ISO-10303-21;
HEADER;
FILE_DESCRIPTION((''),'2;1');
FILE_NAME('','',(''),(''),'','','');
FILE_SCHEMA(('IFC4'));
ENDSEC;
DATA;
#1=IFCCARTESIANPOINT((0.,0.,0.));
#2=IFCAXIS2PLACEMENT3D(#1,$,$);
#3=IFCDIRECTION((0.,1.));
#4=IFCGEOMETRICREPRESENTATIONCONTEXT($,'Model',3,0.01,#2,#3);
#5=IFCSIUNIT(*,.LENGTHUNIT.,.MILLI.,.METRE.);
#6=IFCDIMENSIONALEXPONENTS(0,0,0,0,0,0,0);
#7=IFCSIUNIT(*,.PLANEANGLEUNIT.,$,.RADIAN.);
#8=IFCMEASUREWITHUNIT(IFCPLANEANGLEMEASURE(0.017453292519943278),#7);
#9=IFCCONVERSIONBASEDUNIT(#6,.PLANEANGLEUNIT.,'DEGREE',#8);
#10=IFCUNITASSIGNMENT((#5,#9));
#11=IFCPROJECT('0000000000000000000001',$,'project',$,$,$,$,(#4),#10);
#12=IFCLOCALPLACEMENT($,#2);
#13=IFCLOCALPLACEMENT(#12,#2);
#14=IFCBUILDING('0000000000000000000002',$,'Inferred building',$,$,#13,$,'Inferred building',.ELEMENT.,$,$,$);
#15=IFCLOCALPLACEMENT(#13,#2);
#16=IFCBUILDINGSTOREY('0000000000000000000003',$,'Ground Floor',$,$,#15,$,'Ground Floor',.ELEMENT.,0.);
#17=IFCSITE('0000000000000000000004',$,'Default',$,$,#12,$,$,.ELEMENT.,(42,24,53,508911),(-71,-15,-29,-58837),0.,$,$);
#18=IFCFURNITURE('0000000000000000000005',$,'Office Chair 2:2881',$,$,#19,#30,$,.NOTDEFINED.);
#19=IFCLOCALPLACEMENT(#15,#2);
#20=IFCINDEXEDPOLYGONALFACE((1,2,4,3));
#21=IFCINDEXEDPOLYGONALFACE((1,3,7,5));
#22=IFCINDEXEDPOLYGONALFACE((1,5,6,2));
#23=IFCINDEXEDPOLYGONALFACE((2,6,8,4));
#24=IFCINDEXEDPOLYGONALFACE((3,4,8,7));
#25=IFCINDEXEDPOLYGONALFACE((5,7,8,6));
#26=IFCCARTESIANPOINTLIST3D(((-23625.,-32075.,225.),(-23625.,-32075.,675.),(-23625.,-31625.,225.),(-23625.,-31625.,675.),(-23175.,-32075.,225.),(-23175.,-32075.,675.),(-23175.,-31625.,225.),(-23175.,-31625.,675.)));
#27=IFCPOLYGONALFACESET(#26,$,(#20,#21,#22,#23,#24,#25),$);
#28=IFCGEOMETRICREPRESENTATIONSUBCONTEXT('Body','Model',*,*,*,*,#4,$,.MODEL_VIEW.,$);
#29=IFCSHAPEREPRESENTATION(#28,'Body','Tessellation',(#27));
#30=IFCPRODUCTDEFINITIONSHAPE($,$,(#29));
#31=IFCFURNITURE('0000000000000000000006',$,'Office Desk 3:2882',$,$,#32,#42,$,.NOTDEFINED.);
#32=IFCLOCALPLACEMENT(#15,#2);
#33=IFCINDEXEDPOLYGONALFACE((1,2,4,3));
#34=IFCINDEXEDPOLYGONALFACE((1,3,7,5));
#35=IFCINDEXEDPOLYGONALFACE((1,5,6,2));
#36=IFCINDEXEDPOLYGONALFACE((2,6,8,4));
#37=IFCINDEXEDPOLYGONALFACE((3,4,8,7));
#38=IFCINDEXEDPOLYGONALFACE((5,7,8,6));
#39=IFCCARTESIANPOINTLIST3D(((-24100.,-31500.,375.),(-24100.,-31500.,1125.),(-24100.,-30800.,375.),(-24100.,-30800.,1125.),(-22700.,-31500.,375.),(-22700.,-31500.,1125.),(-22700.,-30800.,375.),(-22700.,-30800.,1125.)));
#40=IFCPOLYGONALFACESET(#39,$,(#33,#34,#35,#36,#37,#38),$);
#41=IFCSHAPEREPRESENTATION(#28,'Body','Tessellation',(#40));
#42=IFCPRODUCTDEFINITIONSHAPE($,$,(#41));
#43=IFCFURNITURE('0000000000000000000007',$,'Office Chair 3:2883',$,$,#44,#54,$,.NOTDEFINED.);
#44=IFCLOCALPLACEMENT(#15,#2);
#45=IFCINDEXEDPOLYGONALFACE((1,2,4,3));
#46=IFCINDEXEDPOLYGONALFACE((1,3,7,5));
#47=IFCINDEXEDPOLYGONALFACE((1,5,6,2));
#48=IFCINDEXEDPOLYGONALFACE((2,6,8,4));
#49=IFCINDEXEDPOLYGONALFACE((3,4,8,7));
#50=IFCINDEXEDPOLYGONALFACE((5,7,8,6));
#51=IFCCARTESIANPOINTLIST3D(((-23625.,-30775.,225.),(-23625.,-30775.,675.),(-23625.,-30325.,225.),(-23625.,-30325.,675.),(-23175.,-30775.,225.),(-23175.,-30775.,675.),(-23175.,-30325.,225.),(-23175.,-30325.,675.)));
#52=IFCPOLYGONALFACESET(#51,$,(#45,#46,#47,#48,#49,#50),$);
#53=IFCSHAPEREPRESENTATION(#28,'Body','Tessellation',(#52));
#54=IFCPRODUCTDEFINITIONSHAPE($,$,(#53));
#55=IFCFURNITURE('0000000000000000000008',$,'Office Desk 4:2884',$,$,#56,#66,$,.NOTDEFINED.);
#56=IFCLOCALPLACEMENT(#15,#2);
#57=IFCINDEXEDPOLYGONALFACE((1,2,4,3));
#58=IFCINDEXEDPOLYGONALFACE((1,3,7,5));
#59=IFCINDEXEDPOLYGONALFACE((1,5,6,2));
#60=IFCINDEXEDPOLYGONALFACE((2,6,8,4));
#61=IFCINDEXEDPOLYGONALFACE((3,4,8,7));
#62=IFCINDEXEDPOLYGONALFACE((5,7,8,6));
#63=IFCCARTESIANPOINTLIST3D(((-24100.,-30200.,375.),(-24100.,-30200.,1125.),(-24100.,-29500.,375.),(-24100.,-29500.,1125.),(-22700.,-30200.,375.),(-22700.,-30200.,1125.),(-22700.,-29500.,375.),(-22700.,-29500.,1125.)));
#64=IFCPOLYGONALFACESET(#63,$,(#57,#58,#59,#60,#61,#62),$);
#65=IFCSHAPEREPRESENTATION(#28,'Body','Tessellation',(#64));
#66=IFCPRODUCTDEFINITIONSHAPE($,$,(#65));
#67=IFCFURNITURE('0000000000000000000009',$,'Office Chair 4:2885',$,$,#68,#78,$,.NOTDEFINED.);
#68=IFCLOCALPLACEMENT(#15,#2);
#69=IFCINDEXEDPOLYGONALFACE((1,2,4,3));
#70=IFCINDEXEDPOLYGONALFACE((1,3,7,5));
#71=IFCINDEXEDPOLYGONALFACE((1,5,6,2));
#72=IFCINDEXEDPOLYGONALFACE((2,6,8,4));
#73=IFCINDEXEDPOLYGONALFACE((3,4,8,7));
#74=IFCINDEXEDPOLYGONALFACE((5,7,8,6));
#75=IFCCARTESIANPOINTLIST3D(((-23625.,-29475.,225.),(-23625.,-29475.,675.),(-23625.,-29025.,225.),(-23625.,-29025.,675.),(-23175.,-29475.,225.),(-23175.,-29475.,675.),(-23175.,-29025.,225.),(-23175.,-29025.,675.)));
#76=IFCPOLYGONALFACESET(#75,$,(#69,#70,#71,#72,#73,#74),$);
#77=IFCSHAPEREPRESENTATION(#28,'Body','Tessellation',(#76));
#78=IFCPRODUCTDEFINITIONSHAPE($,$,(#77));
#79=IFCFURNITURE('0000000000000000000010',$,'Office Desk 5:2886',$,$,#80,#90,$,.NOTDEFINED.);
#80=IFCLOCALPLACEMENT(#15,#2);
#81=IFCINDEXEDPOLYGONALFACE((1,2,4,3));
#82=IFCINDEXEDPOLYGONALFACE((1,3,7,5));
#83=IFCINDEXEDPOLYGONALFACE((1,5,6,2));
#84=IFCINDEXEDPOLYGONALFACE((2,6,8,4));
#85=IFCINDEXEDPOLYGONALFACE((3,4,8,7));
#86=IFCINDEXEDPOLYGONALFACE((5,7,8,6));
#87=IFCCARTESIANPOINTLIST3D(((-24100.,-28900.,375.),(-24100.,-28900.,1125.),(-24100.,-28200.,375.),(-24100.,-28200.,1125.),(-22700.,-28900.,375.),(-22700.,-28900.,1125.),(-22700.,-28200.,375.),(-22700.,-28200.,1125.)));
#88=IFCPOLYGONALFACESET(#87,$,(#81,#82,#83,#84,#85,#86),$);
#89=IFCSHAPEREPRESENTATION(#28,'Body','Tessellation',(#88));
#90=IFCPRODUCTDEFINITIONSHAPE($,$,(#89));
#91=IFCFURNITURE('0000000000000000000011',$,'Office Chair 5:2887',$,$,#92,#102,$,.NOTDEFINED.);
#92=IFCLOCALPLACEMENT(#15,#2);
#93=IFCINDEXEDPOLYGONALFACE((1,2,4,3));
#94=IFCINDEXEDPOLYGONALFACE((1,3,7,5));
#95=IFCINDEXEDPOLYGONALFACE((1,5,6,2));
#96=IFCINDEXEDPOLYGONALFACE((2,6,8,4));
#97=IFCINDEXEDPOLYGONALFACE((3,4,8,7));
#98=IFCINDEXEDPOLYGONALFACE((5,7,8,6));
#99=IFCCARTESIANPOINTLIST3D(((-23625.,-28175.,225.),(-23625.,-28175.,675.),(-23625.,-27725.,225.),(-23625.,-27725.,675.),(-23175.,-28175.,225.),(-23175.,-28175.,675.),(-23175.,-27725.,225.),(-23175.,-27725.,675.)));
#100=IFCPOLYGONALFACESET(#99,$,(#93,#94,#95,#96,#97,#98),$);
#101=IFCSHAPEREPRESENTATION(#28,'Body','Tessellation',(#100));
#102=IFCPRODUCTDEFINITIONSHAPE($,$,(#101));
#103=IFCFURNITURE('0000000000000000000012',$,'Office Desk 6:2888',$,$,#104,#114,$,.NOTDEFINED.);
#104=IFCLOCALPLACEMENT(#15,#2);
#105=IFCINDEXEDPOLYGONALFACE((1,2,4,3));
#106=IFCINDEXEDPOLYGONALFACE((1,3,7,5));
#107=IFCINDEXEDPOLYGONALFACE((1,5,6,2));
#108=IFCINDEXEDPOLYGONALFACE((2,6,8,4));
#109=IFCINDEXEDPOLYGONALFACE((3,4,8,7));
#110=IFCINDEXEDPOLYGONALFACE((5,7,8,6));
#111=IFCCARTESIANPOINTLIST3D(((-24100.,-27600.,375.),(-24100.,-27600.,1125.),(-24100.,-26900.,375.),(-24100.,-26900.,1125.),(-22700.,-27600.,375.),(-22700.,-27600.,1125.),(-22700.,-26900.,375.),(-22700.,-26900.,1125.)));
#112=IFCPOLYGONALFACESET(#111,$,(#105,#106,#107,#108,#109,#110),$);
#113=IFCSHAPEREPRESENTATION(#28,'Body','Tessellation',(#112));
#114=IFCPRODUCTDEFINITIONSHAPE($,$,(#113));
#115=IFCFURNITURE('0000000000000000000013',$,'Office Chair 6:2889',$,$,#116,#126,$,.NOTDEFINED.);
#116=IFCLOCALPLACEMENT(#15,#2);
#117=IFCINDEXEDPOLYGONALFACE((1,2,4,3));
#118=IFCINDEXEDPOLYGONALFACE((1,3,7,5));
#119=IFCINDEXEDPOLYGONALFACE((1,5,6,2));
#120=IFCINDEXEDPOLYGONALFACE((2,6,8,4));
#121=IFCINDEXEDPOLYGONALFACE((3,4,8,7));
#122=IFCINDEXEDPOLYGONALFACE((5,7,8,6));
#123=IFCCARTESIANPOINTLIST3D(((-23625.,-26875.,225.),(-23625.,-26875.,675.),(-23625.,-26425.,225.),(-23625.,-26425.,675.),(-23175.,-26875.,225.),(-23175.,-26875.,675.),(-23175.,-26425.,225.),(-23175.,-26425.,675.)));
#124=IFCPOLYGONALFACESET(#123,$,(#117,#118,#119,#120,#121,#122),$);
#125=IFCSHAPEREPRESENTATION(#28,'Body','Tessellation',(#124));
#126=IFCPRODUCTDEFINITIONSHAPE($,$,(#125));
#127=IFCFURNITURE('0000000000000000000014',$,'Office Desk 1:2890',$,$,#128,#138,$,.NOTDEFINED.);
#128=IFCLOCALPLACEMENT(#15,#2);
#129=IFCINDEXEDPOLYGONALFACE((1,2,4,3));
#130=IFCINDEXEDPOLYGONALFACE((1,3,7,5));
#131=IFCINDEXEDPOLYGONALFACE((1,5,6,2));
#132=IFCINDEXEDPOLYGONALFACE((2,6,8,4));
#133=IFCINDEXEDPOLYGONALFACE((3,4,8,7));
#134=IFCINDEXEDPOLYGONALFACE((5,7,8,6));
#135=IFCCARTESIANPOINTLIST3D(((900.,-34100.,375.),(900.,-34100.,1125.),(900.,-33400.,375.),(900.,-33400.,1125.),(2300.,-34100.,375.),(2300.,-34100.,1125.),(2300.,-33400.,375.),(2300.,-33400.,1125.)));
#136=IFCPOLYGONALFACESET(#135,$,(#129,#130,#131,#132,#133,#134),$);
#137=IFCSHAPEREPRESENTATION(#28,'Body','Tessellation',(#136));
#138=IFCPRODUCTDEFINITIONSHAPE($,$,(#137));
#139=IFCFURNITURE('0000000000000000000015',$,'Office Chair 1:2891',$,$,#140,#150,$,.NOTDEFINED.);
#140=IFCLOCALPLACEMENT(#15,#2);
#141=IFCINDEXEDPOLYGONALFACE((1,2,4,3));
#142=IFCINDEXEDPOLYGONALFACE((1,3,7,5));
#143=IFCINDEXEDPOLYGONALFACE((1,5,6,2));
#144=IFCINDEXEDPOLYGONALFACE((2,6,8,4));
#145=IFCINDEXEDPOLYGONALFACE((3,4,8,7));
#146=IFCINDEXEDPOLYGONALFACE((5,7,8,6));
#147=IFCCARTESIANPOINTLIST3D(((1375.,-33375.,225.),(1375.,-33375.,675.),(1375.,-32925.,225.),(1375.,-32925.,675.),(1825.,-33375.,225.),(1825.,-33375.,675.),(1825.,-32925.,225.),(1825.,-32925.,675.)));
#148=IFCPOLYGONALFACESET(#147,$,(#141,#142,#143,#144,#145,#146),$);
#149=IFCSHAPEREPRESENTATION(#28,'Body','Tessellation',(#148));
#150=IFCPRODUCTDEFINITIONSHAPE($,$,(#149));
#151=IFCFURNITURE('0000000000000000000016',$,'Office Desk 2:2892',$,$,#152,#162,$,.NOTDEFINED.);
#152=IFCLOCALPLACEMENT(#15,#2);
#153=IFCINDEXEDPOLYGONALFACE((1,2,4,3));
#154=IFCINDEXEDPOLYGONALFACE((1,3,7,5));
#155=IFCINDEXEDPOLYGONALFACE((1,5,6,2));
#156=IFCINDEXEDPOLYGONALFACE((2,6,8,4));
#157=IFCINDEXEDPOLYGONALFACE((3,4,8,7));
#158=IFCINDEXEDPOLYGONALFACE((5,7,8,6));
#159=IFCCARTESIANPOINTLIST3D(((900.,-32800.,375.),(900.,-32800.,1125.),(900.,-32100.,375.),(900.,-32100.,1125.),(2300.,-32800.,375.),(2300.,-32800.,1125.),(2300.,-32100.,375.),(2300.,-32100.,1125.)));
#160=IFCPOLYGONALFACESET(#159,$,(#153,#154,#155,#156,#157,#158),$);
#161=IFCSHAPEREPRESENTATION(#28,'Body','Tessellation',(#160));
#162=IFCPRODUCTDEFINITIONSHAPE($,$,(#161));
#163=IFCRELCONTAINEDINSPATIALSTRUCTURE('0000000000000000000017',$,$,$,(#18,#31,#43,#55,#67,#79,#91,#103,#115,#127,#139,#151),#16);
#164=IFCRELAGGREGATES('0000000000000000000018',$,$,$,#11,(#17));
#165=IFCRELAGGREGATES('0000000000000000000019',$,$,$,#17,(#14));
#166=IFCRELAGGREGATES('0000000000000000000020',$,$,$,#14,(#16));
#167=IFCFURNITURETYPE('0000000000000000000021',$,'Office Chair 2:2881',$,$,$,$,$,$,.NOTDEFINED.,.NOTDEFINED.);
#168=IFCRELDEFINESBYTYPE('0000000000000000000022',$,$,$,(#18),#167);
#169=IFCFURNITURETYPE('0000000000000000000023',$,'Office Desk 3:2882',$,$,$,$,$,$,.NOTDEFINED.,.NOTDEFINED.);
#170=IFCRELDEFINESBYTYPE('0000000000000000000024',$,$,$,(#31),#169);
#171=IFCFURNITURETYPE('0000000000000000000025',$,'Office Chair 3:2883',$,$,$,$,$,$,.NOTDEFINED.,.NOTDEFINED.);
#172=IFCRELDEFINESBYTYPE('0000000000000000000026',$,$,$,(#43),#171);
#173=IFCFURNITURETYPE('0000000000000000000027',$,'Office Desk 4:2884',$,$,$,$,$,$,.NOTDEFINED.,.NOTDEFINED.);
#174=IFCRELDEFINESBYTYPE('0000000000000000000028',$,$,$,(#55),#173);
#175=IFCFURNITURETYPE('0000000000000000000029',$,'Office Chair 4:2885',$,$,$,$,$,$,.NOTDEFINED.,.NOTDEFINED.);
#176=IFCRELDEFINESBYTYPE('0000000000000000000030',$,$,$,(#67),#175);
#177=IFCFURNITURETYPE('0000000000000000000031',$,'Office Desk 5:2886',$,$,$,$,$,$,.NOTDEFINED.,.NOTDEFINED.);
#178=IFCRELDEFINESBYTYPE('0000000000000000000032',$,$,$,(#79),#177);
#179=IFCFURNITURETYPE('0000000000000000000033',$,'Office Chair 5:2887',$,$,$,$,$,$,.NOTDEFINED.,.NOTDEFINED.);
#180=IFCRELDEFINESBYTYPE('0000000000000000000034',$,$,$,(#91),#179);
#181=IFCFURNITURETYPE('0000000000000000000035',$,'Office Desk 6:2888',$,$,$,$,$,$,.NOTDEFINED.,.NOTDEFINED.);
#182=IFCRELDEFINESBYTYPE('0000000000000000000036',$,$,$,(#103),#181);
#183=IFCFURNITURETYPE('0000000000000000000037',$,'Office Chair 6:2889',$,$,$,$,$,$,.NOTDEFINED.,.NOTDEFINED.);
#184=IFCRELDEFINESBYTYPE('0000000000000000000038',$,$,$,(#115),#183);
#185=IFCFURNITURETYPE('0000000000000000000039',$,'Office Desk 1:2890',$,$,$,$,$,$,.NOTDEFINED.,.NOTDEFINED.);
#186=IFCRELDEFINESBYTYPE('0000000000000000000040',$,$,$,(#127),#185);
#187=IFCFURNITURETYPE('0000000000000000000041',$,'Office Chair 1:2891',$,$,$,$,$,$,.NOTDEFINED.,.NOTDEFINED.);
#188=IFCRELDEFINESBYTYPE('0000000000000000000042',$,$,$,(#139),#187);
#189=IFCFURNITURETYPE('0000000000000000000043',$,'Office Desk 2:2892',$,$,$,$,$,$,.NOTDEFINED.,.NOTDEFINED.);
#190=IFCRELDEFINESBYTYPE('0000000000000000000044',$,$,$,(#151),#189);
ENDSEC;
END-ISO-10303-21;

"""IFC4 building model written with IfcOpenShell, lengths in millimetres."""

from ifc_helpers import new_model, entity, si_unit, converted_unit, direction, frame, origin, origin_2d_with_axis, place, context, subcontext, project, spatial, rectangle, extrude, type_object, element, save


model = new_model("IFC4")

# Units and contexts
model_context = context("Model", 3, precision=0.01, world=origin(), true_north=direction((0.0, 1.0)))
body_context = subcontext(model_context, "Body", "Model", "MODEL_VIEW")
ifc_project = project(units=[si_unit("LENGTHUNIT", "METRE", prefix="MILLI"), converted_unit("PLANEANGLEUNIT", "DEGREE", entity("IfcPlaneAngleMeasure", 0.017453292519943278), si_unit("PLANEANGLEUNIT", "RADIAN"), dimensions=[0, 0, 0, 0, 0, 0, 0])], contexts=[model_context])

# Site, building, storey
site_placement = place(None, origin())
site = spatial("IfcSite", under=ifc_project, at=site_placement, Name="Default", CompositionType="ELEMENT", RefLatitude=(42, 24, 53, 508911), RefLongitude=(-71, -15, -29, -58837), RefElevation=0.0)
building_placement = place(site_placement, origin())
building = spatial("IfcBuilding", under=site, at=building_placement, Name="Inferred building", LongName="Inferred building", CompositionType="ELEMENT")
storey_placement = place(building_placement, origin())
storey = spatial("IfcBuildingStorey", under=building, at=storey_placement, Name="Ground Floor", LongName="Ground Floor", CompositionType="ELEMENT", Elevation=0.0)

# Furniture
furniture_type_1 = type_object("IfcFurnitureType", Name="Office Chair 2:2881", PredefinedType="NOTDEFINED")
furniture_1_placement = place(storey_placement, origin())
element("IfcFurniture", 1, at=furniture_1_placement, inside=storey, type_object=furniture_type_1, Name="Office Chair 2:2881", PredefinedType="NOTDEFINED", context=body_context, shape_type="SweptSolid", body=[
    extrude(rectangle(XDim=450.0, YDim=450.0, at=origin_2d_with_axis()), frame((-23400.0, -31850.0, 225.0)), (0.0, 0.0, 1.0), 450.0),
])
furniture_type_2 = type_object("IfcFurnitureType", Name="Office Desk 3:2882", PredefinedType="NOTDEFINED")
furniture_2_placement = place(storey_placement, origin())
element("IfcFurniture", 2, at=furniture_2_placement, inside=storey, type_object=furniture_type_2, Name="Office Desk 3:2882", PredefinedType="NOTDEFINED", context=body_context, shape_type="SweptSolid", body=[
    extrude(rectangle(XDim=1400.0, YDim=700.0, at=origin_2d_with_axis()), frame((-23400.0, -31150.0, 375.0)), (0.0, 0.0, 1.0), 750.0),
])
furniture_type_3 = type_object("IfcFurnitureType", Name="Office Chair 3:2883", PredefinedType="NOTDEFINED")
furniture_3_placement = place(storey_placement, origin())
element("IfcFurniture", 3, at=furniture_3_placement, inside=storey, type_object=furniture_type_3, Name="Office Chair 3:2883", PredefinedType="NOTDEFINED", context=body_context, shape_type="SweptSolid", body=[
    extrude(rectangle(XDim=450.0, YDim=450.0, at=origin_2d_with_axis()), frame((-23400.0, -30550.0, 225.0)), (0.0, 0.0, 1.0), 450.0),
])
furniture_type_4 = type_object("IfcFurnitureType", Name="Office Desk 4:2884", PredefinedType="NOTDEFINED")
furniture_4_placement = place(storey_placement, origin())
element("IfcFurniture", 4, at=furniture_4_placement, inside=storey, type_object=furniture_type_4, Name="Office Desk 4:2884", PredefinedType="NOTDEFINED", context=body_context, shape_type="SweptSolid", body=[
    extrude(rectangle(XDim=1400.0, YDim=700.0, at=origin_2d_with_axis()), frame((-23400.0, -29850.0, 375.0)), (0.0, 0.0, 1.0), 750.0),
])
furniture_type_5 = type_object("IfcFurnitureType", Name="Office Chair 4:2885", PredefinedType="NOTDEFINED")
furniture_5_placement = place(storey_placement, origin())
element("IfcFurniture", 5, at=furniture_5_placement, inside=storey, type_object=furniture_type_5, Name="Office Chair 4:2885", PredefinedType="NOTDEFINED", context=body_context, shape_type="SweptSolid", body=[
    extrude(rectangle(XDim=450.0, YDim=450.0, at=origin_2d_with_axis()), frame((-23400.0, -29250.0, 225.0)), (0.0, 0.0, 1.0), 450.0),
])
furniture_type_6 = type_object("IfcFurnitureType", Name="Office Desk 5:2886", PredefinedType="NOTDEFINED")
furniture_6_placement = place(storey_placement, origin())
element("IfcFurniture", 6, at=furniture_6_placement, inside=storey, type_object=furniture_type_6, Name="Office Desk 5:2886", PredefinedType="NOTDEFINED", context=body_context, shape_type="SweptSolid", body=[
    extrude(rectangle(XDim=1400.0, YDim=700.0, at=origin_2d_with_axis()), frame((-23400.0, -28550.0, 375.0)), (0.0, 0.0, 1.0), 750.0),
])
furniture_type_7 = type_object("IfcFurnitureType", Name="Office Chair 5:2887", PredefinedType="NOTDEFINED")
furniture_7_placement = place(storey_placement, origin())
element("IfcFurniture", 7, at=furniture_7_placement, inside=storey, type_object=furniture_type_7, Name="Office Chair 5:2887", PredefinedType="NOTDEFINED", context=body_context, shape_type="SweptSolid", body=[
    extrude(rectangle(XDim=450.0, YDim=450.0, at=origin_2d_with_axis()), frame((-23400.0, -27950.0, 225.0)), (0.0, 0.0, 1.0), 450.0),
])
furniture_type_8 = type_object("IfcFurnitureType", Name="Office Desk 6:2888", PredefinedType="NOTDEFINED")
furniture_8_placement = place(storey_placement, origin())
element("IfcFurniture", 8, at=furniture_8_placement, inside=storey, type_object=furniture_type_8, Name="Office Desk 6:2888", PredefinedType="NOTDEFINED", context=body_context, shape_type="SweptSolid", body=[
    extrude(rectangle(XDim=1400.0, YDim=700.0, at=origin_2d_with_axis()), frame((-23400.0, -27250.0, 375.0)), (0.0, 0.0, 1.0), 750.0),
])
furniture_type_9 = type_object("IfcFurnitureType", Name="Office Chair 6:2889", PredefinedType="NOTDEFINED")
furniture_9_placement = place(storey_placement, origin())
element("IfcFurniture", 9, at=furniture_9_placement, inside=storey, type_object=furniture_type_9, Name="Office Chair 6:2889", PredefinedType="NOTDEFINED", context=body_context, shape_type="SweptSolid", body=[
    extrude(rectangle(XDim=450.0, YDim=450.0, at=origin_2d_with_axis()), frame((-23400.0, -26650.0, 225.0)), (0.0, 0.0, 1.0), 450.0),
])
furniture_type_10 = type_object("IfcFurnitureType", Name="Office Desk 1:2890", PredefinedType="NOTDEFINED")
furniture_10_placement = place(storey_placement, origin())
element("IfcFurniture", 10, at=furniture_10_placement, inside=storey, type_object=furniture_type_10, Name="Office Desk 1:2890", PredefinedType="NOTDEFINED", context=body_context, shape_type="SweptSolid", body=[
    extrude(rectangle(XDim=1400.0, YDim=700.0, at=origin_2d_with_axis()), frame((1600.0, -33750.0, 375.0)), (0.0, 0.0, 1.0), 750.0),
])
furniture_type_11 = type_object("IfcFurnitureType", Name="Office Chair 1:2891", PredefinedType="NOTDEFINED")
furniture_11_placement = place(storey_placement, origin())
element("IfcFurniture", 11, at=furniture_11_placement, inside=storey, type_object=furniture_type_11, Name="Office Chair 1:2891", PredefinedType="NOTDEFINED", context=body_context, shape_type="SweptSolid", body=[
    extrude(rectangle(XDim=450.0, YDim=450.0, at=origin_2d_with_axis()), frame((1600.0, -33150.0, 225.0)), (0.0, 0.0, 1.0), 450.0),
])
furniture_type_12 = type_object("IfcFurnitureType", Name="Office Desk 2:2892", PredefinedType="NOTDEFINED")
furniture_12_placement = place(storey_placement, origin())
element("IfcFurniture", 12, at=furniture_12_placement, inside=storey, type_object=furniture_type_12, Name="Office Desk 2:2892", PredefinedType="NOTDEFINED", context=body_context, shape_type="SweptSolid", body=[
    extrude(rectangle(XDim=1400.0, YDim=700.0, at=origin_2d_with_axis()), frame((1600.0, -32450.0, 375.0)), (0.0, 0.0, 1.0), 750.0),
])

save(model, "model.ifc")
